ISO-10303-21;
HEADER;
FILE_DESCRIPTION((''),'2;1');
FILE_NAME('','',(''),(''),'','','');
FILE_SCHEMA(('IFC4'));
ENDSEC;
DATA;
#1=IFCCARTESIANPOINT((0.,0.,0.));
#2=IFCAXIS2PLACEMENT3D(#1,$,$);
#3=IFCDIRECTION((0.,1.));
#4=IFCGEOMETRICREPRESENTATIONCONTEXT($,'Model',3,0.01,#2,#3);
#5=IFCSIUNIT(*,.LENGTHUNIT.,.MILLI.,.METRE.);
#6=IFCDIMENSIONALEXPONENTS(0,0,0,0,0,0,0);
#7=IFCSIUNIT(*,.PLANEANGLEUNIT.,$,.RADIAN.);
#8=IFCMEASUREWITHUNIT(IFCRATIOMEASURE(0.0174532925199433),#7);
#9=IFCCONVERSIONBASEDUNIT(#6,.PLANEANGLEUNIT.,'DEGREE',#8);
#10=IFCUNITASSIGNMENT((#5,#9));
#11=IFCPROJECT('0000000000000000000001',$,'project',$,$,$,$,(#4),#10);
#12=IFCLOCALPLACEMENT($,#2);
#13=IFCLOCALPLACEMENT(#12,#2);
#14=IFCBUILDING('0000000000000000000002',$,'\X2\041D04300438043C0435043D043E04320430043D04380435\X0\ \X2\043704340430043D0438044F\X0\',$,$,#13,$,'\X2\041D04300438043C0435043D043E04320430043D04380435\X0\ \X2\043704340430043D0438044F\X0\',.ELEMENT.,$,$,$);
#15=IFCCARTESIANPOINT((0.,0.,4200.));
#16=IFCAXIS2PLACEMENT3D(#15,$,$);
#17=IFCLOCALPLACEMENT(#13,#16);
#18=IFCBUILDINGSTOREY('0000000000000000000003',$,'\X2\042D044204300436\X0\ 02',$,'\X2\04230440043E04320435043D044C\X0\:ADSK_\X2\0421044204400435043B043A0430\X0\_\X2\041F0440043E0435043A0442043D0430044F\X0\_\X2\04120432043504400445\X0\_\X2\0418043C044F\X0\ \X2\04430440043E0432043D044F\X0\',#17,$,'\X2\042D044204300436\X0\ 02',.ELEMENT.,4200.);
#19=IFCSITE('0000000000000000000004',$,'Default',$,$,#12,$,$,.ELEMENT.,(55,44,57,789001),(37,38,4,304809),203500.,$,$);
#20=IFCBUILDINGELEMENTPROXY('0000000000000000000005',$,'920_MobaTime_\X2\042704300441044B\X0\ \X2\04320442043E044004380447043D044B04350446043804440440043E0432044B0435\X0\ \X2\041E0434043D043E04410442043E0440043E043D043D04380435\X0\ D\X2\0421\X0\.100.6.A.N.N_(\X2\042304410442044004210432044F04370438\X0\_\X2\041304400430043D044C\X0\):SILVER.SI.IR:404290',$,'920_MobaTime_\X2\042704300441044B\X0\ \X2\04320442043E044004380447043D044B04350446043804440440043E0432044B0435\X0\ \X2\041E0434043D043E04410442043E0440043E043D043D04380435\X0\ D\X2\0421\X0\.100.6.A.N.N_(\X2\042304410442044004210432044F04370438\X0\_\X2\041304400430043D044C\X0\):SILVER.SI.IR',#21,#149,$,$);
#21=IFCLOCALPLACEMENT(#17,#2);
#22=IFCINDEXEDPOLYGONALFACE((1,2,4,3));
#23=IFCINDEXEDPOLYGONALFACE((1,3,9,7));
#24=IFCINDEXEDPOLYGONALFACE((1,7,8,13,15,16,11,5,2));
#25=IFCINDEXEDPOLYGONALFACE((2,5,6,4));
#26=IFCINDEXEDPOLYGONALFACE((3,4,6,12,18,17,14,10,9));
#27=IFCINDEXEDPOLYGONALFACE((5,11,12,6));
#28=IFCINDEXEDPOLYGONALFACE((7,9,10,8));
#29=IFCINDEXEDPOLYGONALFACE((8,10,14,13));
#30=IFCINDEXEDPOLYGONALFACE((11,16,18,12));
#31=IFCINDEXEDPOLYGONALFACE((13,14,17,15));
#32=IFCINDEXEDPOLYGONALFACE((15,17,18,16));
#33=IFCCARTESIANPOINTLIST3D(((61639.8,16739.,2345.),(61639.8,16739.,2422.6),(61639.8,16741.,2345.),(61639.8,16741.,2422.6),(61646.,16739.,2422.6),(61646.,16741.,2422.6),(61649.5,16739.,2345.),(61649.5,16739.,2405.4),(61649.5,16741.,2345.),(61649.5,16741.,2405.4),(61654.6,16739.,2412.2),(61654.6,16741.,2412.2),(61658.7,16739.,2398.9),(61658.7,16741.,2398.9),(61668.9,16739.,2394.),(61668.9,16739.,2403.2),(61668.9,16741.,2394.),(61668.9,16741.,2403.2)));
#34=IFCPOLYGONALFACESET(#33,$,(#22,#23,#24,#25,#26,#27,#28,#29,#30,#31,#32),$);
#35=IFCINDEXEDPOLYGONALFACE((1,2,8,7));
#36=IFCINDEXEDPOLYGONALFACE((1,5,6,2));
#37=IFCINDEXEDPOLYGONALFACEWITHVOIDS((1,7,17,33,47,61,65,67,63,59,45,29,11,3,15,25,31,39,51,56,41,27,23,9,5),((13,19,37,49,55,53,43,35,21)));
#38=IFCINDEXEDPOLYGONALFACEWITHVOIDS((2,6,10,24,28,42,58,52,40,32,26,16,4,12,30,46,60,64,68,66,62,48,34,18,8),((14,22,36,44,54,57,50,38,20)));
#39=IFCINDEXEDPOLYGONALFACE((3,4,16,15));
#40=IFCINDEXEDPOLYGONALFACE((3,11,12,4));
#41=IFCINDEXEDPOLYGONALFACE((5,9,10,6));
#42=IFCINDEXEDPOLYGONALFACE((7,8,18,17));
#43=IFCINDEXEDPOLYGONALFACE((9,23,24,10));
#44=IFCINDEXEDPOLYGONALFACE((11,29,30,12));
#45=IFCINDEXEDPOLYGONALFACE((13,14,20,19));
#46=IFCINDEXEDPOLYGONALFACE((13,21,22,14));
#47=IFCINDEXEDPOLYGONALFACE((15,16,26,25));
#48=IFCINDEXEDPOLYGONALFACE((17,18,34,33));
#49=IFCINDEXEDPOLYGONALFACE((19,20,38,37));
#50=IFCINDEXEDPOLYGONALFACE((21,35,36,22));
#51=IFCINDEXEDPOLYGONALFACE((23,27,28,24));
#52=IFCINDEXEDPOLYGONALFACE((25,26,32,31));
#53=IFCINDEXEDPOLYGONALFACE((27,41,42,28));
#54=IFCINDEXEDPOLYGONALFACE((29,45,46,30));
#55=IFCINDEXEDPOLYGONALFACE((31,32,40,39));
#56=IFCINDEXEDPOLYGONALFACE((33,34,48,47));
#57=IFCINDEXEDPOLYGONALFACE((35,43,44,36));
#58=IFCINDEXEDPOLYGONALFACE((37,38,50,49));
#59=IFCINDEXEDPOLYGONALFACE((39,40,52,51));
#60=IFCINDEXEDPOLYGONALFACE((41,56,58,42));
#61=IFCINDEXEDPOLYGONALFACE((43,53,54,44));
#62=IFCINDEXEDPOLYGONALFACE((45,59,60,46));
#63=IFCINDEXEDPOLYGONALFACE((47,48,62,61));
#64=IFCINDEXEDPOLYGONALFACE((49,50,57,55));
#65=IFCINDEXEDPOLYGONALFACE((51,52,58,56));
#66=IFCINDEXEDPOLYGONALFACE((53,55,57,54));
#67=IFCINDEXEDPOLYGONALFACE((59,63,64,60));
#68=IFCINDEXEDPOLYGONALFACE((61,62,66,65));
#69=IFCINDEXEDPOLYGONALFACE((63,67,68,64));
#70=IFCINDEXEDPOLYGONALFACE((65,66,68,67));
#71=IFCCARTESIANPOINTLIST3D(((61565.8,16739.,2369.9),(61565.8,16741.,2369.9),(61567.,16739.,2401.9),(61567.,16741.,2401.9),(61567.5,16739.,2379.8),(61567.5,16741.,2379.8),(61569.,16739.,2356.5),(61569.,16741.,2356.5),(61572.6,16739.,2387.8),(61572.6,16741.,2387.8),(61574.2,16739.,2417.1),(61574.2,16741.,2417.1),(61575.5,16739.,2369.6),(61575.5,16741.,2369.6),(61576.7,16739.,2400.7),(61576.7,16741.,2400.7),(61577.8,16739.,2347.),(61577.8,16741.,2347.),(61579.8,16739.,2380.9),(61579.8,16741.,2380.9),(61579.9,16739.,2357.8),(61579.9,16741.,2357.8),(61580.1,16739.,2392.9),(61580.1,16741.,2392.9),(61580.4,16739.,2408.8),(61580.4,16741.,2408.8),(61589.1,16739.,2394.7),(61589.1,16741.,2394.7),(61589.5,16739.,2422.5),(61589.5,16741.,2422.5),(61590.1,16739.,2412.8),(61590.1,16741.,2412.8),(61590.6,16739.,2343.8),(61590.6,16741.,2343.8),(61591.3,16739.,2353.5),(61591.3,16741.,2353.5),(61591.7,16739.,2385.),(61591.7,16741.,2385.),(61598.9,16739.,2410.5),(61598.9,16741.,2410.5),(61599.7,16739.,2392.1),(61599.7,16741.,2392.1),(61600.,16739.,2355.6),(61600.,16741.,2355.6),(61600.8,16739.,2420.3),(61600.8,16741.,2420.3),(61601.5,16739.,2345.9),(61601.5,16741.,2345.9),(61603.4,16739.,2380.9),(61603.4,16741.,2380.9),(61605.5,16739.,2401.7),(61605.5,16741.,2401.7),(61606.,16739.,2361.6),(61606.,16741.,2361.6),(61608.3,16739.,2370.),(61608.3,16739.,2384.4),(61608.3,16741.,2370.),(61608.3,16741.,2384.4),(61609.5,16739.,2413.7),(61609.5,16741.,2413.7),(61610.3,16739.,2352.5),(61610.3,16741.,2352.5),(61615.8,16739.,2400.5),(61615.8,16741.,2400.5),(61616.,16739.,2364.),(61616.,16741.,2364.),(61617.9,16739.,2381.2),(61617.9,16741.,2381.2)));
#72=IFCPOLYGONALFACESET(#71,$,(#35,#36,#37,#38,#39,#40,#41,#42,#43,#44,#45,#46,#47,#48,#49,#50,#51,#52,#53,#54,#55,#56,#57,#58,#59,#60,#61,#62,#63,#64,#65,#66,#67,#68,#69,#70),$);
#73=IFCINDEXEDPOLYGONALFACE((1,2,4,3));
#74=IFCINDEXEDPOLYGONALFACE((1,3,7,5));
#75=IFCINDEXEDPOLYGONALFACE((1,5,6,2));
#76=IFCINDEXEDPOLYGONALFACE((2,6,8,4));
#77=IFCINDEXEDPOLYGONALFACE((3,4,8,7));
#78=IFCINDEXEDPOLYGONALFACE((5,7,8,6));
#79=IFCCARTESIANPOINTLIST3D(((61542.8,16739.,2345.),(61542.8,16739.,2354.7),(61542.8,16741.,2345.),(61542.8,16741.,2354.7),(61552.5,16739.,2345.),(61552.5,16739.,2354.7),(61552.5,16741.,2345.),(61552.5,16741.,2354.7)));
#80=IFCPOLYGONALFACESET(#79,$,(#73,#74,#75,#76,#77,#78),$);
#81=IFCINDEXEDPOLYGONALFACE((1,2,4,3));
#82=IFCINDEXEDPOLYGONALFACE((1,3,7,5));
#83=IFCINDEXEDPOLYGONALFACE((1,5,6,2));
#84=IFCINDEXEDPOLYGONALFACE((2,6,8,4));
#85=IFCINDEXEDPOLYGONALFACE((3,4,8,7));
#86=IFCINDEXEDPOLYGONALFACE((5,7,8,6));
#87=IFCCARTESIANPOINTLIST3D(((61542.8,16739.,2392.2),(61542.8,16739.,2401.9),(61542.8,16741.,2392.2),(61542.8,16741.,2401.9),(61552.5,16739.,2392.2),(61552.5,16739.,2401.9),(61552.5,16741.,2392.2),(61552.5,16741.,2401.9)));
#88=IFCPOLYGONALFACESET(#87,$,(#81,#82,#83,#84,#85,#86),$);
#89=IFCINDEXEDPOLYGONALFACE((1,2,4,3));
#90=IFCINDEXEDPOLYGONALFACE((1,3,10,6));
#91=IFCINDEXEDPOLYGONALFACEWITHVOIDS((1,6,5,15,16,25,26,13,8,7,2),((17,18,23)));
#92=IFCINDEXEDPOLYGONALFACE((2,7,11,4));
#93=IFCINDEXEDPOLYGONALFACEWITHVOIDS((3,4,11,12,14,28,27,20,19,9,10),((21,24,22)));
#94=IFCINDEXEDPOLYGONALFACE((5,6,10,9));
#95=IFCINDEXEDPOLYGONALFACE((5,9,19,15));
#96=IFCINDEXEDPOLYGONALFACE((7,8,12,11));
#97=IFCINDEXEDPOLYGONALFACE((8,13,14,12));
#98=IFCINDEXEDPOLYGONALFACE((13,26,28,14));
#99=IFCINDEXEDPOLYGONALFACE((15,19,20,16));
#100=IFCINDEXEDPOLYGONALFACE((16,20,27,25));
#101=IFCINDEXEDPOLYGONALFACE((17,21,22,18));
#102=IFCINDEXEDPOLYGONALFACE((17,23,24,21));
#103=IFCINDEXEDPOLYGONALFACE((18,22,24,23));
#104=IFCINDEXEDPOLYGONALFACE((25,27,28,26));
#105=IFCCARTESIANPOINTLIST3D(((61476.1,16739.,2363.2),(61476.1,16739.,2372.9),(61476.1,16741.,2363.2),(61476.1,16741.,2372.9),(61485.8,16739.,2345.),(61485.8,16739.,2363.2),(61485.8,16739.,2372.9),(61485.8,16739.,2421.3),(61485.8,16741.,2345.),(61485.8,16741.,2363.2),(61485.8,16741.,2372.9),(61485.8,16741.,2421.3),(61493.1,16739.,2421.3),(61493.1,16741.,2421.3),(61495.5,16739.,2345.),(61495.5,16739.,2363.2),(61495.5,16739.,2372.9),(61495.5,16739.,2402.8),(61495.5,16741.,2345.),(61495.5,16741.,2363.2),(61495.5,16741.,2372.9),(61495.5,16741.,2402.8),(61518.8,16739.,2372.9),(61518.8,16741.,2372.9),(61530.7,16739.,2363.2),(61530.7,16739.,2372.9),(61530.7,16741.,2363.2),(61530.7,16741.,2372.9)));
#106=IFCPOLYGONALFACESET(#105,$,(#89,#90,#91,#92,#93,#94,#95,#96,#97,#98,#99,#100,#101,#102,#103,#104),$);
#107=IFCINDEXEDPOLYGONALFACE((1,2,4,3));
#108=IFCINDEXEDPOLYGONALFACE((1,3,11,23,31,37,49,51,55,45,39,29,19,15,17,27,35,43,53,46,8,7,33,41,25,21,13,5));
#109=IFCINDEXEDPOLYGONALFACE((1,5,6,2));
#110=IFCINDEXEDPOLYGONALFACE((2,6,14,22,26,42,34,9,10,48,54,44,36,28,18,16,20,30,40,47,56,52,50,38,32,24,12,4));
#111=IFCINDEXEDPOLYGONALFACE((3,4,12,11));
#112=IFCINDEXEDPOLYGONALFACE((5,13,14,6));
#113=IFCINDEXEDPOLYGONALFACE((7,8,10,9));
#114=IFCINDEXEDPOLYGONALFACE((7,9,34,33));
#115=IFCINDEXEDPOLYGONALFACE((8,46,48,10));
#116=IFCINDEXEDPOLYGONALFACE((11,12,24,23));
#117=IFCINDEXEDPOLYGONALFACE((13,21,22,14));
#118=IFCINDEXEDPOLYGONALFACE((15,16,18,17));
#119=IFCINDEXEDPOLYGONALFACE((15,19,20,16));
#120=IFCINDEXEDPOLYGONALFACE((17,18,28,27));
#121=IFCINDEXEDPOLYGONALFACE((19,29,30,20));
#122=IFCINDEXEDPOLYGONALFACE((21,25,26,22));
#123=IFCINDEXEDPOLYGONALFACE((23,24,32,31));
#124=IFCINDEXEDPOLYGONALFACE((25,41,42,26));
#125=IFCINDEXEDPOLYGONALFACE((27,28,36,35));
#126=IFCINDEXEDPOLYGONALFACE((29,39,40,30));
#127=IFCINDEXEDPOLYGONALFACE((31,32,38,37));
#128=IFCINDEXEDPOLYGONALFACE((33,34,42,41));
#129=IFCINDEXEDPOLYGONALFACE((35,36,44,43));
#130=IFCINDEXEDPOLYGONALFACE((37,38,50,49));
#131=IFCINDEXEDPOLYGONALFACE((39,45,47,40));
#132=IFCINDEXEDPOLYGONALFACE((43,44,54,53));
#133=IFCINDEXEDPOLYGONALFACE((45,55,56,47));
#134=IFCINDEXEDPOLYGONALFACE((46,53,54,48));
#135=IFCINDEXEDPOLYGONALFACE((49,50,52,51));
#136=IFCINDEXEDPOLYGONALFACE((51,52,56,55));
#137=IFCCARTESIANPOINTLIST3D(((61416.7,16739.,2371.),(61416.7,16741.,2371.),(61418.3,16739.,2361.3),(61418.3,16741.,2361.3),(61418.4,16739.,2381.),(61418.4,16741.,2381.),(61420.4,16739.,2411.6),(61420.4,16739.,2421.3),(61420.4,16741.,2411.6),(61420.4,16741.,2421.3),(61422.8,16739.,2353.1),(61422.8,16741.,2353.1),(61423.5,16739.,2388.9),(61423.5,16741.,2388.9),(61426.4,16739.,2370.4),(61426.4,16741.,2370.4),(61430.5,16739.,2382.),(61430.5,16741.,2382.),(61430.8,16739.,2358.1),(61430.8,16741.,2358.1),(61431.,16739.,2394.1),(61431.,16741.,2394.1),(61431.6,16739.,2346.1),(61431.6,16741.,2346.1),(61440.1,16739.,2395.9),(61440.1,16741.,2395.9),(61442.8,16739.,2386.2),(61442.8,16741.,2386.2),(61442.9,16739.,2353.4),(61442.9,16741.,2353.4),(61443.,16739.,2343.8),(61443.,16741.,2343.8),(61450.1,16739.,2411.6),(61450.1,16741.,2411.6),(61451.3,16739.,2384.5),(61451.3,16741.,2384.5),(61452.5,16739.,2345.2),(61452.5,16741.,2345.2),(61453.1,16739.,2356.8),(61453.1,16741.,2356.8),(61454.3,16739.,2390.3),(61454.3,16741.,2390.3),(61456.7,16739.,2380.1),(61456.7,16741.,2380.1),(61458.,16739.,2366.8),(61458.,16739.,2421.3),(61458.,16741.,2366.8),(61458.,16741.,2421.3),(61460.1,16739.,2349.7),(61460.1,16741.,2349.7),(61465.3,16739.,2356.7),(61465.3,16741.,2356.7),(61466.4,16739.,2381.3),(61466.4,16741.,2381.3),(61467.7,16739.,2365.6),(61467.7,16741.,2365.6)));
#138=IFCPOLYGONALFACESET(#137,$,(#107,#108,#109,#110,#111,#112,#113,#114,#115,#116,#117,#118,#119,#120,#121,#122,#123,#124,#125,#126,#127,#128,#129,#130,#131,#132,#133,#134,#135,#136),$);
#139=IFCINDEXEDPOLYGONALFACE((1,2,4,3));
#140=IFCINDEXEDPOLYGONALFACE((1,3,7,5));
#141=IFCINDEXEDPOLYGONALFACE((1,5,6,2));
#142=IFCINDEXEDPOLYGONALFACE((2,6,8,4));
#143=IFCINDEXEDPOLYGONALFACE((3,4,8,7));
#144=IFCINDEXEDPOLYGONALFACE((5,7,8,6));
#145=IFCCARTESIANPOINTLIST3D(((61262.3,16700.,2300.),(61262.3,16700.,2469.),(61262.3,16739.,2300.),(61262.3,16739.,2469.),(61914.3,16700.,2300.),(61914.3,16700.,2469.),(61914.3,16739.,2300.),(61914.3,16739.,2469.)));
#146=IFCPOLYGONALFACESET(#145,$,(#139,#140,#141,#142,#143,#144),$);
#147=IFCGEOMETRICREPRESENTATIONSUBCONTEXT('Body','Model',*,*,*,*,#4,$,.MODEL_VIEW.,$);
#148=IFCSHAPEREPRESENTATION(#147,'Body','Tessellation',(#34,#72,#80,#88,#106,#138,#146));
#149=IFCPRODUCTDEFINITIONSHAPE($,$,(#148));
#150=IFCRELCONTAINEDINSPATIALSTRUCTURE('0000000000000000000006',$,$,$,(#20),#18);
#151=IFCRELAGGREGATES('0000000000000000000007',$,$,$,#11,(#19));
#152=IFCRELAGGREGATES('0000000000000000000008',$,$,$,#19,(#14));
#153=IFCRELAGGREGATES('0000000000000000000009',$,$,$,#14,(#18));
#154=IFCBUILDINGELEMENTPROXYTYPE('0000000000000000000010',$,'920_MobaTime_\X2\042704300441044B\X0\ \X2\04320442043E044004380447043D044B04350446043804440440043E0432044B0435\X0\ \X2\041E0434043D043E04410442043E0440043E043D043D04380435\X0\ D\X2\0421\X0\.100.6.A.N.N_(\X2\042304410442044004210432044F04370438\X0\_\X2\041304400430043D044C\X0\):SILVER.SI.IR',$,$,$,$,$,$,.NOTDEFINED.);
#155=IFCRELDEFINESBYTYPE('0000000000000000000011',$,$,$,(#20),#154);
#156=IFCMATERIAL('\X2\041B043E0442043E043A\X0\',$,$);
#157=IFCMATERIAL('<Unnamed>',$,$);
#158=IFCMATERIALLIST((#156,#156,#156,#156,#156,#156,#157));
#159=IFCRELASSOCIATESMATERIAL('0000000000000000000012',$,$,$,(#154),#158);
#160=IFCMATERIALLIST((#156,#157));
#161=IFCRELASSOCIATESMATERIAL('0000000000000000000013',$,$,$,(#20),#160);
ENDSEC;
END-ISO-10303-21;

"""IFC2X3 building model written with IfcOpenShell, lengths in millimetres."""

from ifc_helpers import new_model, entity, si_unit, converted_unit, direction, frame, origin, origin_2d_with_axis, place, context, subcontext, project, spatial, polyline, rectangle, outline, extrude, source, transform, mapped, material, material_list, type_object, type_shapes, element, save


model = new_model("IFC2X3")

# Units and contexts
model_context = context("Model", 3, precision=0.01, world=origin(), true_north=direction((0.0, 1.0)))
body_context = subcontext(model_context, "Body", "Model", "MODEL_VIEW")
ifc_project = project(units=[si_unit("LENGTHUNIT", "METRE", prefix="MILLI"), converted_unit("PLANEANGLEUNIT", "DEGREE", entity("IfcRatioMeasure", 0.0174532925199433), si_unit("PLANEANGLEUNIT", "RADIAN"), dimensions=[0, 0, 0, 0, 0, 0, 0])], contexts=[model_context])

# Site, building, storey
site_placement = place(None, origin())
site = spatial("IfcSite", under=ifc_project, at=site_placement, Name="Default", CompositionType="ELEMENT", RefLatitude=(55, 44, 57, 789001), RefLongitude=(37, 38, 4, 304809), RefElevation=203500.0)
building_placement = place(site_placement, origin())
building = spatial("IfcBuilding", under=site, at=building_placement, Name="Наименование здания", LongName="Наименование здания", CompositionType="ELEMENT")
storey_placement = place(building_placement, frame((0.0, 0.0, 4200.0)))
storey = spatial("IfcBuildingStorey", under=building, at=storey_placement, Name="Этаж 02", ObjectType="Уровень:ADSK_Стрелка_Проектная_Вверх_Имя уровня", LongName="Этаж 02", CompositionType="ELEMENT", Elevation=4200.0)

# Building element proxy
ifc_material_1 = material(Name="Лоток")
ifc_material_2 = material(Name="<Unnamed>")
ifc_material_list_1 = material_list([ifc_material_1, ifc_material_2])
ifc_material_list_2 = material_list([ifc_material_1, ifc_material_1, ifc_material_1, ifc_material_1, ifc_material_1, ifc_material_1, ifc_material_2])
building_element_proxy_type_1 = type_object("IfcBuildingElementProxyType", Name="920_MobaTime_Часы вторичныецифровые Односторонние DС.100.6.A.N.N_(УстрСвязи_Грань):SILVER.SI.IR", PredefinedType="NOTDEFINED", material=ifc_material_list_2)
shared_shape_1 = source(origin(), body_context, "Body", "SweptSolid", [
    extrude(outline(polyline([(-49.3, -13.1), (28.2, -13.1), (28.2, -6.8), (17.9, 1.8), (8.8, 16.0), (-0.3, 16.0), (4.6, 5.8), (11.1, -3.4), (-49.3, -3.4), (-49.3, -13.1)])), frame((-64.6, 9.8, 39.0), z_axis=(0.0, 0.0, 1.0), x_axis=(0.0, 1.0, 0.0)), (0.0, 0.0, 1.0), 2.0),
    extrude(outline(polyline([(2.2, -27.6), (19.0, -27.6), (30.5, -16.1), (33.3, -4.9), (31.0, 5.8), (21.8, 17.2), (5.2, 27.3), (-11.1, 33.0), (-24.0, 32.7), (-33.6, 27.6), (-40.3, 18.6), (-42.8, 5.7), (-38.0, -6.3), (-27.2, -14.9), (-17.5, -17.7), (-8.2, -16.4), (-0.3, -11.9), (5.1, -4.5), (7.3, 6.2), (4.0, 17.2), (18.4, 7.3), (23.6, -2.4), (22.0, -11.4), (14.2, -18.4), (5.3, -18.3), (2.2, -27.6)]), holes=[polyline([(-9.0, 23.3), (-1.3, 14.3), (-2.5, 2.0), (-11.4, -7.0), (-23.4, -6.0), (-32.2, 2.9), (-31.2, 15.1), (-25.6, 22.1), (-17.5, 24.9), (-9.0, 23.3)])]), frame((-2.7, 3.6, 39.0), z_axis=(0.0, 0.0, 1.0), x_axis=(-0.427649, 0.903945, 0.0)), (0.0, 0.0, 1.0), 2.0),
    extrude(rectangle(XDim=9.7, YDim=9.7, at=origin_2d_with_axis()), frame((40.6, -34.7, 39.0)), (0.0, 0.0, 1.0), 2.0),
    extrude(rectangle(XDim=9.7, YDim=9.7, at=origin_2d_with_axis()), frame((40.6, 12.6, 39.0)), (0.0, 0.0, 1.0), 2.0),
    extrude(outline(polyline([(-0.9, -28.1), (8.8, -28.1), (8.8, -9.9), (18.5, -9.9), (18.5, -0.2), (8.8, -0.2), (8.8, 48.3), (1.5, 48.3), (-36.0, -0.2), (-36.0, -9.9), (-0.9, -9.9), (-0.9, -28.1)]), holes=[polyline([(-0.9, -0.2), (-24.1, -0.2), (-0.9, 29.7), (-0.9, -0.2)])]), frame((93.6, -11.4, 39.0)), (0.0, 0.0, 1.0), 2.0),
    extrude(outline(polyline([(3.3, -28.3), (12.5, -28.3), (20.5, -25.0), (26.8, -18.9), (30.7, -10.0), (31.4, 1.6), (26.9, 11.8), (20.1, 18.4), (11.1, 22.3), (1.0, 23.3), (-7.9, 20.4), (-14.9, 14.5), (-18.9, 6.2), (-17.1, -9.0), (-36.7, 0.5), (-29.1, 29.2), (-38.5, 31.7), (-48.1, -4.6), (-11.6, -23.1), (-8.0, -14.0), (-10.8, -7.6), (-10.2, 1.1), (-3.0, 11.8), (9.2, 12.8), (20.0, 5.5), (21.4, -7.5), (15.5, -16.4), (4.6, -18.6), (3.3, -28.3)])), frame((147.1, -8.5, 39.0), z_axis=(0.0, 0.0, 1.0), x_axis=(0.256974, -0.966418, 0.0)), (0.0, 0.0, 1.0), 2.0),
    extrude(rectangle(XDim=652.0, YDim=169.0, at=origin_2d_with_axis()), frame((0.0, 0.0, 0.0), z_axis=(0.0, 0.0, 1.0), x_axis=(-1.0, 0.0, 0.0)), (0.0, 0.0, 1.0), 39.0),
])
type_shapes(building_element_proxy_type_1, [shared_shape_1])
for number, where, z_axis, x_axis, name in (
    (1, (61588.3, 16700.0, 2384.5), (0.0, 1.0, 0.0), (-1.0, 0.0, 0.0), "920_MobaTime_Часы вторичныецифровые Односторонние DС.100.6.A.N.N_(УстрСвязи_Грань):SILVER.SI.IR:404290"),
):
    element("IfcBuildingElementProxy", number, at=place(storey_placement, frame(where, z_axis=z_axis, x_axis=x_axis)), inside=storey, type_object=building_element_proxy_type_1, material=ifc_material_list_1, Name=name, ObjectType="920_MobaTime_Часы вторичныецифровые Односторонние DС.100.6.A.N.N_(УстрСвязи_Грань):SILVER.SI.IR", context=body_context, shape_type="MappedRepresentation", body=[
        mapped(shared_shape_1, transform((0.0, 0.0, 0.0), scale=1.0)),
    ])

save(model, "model.ifc")
